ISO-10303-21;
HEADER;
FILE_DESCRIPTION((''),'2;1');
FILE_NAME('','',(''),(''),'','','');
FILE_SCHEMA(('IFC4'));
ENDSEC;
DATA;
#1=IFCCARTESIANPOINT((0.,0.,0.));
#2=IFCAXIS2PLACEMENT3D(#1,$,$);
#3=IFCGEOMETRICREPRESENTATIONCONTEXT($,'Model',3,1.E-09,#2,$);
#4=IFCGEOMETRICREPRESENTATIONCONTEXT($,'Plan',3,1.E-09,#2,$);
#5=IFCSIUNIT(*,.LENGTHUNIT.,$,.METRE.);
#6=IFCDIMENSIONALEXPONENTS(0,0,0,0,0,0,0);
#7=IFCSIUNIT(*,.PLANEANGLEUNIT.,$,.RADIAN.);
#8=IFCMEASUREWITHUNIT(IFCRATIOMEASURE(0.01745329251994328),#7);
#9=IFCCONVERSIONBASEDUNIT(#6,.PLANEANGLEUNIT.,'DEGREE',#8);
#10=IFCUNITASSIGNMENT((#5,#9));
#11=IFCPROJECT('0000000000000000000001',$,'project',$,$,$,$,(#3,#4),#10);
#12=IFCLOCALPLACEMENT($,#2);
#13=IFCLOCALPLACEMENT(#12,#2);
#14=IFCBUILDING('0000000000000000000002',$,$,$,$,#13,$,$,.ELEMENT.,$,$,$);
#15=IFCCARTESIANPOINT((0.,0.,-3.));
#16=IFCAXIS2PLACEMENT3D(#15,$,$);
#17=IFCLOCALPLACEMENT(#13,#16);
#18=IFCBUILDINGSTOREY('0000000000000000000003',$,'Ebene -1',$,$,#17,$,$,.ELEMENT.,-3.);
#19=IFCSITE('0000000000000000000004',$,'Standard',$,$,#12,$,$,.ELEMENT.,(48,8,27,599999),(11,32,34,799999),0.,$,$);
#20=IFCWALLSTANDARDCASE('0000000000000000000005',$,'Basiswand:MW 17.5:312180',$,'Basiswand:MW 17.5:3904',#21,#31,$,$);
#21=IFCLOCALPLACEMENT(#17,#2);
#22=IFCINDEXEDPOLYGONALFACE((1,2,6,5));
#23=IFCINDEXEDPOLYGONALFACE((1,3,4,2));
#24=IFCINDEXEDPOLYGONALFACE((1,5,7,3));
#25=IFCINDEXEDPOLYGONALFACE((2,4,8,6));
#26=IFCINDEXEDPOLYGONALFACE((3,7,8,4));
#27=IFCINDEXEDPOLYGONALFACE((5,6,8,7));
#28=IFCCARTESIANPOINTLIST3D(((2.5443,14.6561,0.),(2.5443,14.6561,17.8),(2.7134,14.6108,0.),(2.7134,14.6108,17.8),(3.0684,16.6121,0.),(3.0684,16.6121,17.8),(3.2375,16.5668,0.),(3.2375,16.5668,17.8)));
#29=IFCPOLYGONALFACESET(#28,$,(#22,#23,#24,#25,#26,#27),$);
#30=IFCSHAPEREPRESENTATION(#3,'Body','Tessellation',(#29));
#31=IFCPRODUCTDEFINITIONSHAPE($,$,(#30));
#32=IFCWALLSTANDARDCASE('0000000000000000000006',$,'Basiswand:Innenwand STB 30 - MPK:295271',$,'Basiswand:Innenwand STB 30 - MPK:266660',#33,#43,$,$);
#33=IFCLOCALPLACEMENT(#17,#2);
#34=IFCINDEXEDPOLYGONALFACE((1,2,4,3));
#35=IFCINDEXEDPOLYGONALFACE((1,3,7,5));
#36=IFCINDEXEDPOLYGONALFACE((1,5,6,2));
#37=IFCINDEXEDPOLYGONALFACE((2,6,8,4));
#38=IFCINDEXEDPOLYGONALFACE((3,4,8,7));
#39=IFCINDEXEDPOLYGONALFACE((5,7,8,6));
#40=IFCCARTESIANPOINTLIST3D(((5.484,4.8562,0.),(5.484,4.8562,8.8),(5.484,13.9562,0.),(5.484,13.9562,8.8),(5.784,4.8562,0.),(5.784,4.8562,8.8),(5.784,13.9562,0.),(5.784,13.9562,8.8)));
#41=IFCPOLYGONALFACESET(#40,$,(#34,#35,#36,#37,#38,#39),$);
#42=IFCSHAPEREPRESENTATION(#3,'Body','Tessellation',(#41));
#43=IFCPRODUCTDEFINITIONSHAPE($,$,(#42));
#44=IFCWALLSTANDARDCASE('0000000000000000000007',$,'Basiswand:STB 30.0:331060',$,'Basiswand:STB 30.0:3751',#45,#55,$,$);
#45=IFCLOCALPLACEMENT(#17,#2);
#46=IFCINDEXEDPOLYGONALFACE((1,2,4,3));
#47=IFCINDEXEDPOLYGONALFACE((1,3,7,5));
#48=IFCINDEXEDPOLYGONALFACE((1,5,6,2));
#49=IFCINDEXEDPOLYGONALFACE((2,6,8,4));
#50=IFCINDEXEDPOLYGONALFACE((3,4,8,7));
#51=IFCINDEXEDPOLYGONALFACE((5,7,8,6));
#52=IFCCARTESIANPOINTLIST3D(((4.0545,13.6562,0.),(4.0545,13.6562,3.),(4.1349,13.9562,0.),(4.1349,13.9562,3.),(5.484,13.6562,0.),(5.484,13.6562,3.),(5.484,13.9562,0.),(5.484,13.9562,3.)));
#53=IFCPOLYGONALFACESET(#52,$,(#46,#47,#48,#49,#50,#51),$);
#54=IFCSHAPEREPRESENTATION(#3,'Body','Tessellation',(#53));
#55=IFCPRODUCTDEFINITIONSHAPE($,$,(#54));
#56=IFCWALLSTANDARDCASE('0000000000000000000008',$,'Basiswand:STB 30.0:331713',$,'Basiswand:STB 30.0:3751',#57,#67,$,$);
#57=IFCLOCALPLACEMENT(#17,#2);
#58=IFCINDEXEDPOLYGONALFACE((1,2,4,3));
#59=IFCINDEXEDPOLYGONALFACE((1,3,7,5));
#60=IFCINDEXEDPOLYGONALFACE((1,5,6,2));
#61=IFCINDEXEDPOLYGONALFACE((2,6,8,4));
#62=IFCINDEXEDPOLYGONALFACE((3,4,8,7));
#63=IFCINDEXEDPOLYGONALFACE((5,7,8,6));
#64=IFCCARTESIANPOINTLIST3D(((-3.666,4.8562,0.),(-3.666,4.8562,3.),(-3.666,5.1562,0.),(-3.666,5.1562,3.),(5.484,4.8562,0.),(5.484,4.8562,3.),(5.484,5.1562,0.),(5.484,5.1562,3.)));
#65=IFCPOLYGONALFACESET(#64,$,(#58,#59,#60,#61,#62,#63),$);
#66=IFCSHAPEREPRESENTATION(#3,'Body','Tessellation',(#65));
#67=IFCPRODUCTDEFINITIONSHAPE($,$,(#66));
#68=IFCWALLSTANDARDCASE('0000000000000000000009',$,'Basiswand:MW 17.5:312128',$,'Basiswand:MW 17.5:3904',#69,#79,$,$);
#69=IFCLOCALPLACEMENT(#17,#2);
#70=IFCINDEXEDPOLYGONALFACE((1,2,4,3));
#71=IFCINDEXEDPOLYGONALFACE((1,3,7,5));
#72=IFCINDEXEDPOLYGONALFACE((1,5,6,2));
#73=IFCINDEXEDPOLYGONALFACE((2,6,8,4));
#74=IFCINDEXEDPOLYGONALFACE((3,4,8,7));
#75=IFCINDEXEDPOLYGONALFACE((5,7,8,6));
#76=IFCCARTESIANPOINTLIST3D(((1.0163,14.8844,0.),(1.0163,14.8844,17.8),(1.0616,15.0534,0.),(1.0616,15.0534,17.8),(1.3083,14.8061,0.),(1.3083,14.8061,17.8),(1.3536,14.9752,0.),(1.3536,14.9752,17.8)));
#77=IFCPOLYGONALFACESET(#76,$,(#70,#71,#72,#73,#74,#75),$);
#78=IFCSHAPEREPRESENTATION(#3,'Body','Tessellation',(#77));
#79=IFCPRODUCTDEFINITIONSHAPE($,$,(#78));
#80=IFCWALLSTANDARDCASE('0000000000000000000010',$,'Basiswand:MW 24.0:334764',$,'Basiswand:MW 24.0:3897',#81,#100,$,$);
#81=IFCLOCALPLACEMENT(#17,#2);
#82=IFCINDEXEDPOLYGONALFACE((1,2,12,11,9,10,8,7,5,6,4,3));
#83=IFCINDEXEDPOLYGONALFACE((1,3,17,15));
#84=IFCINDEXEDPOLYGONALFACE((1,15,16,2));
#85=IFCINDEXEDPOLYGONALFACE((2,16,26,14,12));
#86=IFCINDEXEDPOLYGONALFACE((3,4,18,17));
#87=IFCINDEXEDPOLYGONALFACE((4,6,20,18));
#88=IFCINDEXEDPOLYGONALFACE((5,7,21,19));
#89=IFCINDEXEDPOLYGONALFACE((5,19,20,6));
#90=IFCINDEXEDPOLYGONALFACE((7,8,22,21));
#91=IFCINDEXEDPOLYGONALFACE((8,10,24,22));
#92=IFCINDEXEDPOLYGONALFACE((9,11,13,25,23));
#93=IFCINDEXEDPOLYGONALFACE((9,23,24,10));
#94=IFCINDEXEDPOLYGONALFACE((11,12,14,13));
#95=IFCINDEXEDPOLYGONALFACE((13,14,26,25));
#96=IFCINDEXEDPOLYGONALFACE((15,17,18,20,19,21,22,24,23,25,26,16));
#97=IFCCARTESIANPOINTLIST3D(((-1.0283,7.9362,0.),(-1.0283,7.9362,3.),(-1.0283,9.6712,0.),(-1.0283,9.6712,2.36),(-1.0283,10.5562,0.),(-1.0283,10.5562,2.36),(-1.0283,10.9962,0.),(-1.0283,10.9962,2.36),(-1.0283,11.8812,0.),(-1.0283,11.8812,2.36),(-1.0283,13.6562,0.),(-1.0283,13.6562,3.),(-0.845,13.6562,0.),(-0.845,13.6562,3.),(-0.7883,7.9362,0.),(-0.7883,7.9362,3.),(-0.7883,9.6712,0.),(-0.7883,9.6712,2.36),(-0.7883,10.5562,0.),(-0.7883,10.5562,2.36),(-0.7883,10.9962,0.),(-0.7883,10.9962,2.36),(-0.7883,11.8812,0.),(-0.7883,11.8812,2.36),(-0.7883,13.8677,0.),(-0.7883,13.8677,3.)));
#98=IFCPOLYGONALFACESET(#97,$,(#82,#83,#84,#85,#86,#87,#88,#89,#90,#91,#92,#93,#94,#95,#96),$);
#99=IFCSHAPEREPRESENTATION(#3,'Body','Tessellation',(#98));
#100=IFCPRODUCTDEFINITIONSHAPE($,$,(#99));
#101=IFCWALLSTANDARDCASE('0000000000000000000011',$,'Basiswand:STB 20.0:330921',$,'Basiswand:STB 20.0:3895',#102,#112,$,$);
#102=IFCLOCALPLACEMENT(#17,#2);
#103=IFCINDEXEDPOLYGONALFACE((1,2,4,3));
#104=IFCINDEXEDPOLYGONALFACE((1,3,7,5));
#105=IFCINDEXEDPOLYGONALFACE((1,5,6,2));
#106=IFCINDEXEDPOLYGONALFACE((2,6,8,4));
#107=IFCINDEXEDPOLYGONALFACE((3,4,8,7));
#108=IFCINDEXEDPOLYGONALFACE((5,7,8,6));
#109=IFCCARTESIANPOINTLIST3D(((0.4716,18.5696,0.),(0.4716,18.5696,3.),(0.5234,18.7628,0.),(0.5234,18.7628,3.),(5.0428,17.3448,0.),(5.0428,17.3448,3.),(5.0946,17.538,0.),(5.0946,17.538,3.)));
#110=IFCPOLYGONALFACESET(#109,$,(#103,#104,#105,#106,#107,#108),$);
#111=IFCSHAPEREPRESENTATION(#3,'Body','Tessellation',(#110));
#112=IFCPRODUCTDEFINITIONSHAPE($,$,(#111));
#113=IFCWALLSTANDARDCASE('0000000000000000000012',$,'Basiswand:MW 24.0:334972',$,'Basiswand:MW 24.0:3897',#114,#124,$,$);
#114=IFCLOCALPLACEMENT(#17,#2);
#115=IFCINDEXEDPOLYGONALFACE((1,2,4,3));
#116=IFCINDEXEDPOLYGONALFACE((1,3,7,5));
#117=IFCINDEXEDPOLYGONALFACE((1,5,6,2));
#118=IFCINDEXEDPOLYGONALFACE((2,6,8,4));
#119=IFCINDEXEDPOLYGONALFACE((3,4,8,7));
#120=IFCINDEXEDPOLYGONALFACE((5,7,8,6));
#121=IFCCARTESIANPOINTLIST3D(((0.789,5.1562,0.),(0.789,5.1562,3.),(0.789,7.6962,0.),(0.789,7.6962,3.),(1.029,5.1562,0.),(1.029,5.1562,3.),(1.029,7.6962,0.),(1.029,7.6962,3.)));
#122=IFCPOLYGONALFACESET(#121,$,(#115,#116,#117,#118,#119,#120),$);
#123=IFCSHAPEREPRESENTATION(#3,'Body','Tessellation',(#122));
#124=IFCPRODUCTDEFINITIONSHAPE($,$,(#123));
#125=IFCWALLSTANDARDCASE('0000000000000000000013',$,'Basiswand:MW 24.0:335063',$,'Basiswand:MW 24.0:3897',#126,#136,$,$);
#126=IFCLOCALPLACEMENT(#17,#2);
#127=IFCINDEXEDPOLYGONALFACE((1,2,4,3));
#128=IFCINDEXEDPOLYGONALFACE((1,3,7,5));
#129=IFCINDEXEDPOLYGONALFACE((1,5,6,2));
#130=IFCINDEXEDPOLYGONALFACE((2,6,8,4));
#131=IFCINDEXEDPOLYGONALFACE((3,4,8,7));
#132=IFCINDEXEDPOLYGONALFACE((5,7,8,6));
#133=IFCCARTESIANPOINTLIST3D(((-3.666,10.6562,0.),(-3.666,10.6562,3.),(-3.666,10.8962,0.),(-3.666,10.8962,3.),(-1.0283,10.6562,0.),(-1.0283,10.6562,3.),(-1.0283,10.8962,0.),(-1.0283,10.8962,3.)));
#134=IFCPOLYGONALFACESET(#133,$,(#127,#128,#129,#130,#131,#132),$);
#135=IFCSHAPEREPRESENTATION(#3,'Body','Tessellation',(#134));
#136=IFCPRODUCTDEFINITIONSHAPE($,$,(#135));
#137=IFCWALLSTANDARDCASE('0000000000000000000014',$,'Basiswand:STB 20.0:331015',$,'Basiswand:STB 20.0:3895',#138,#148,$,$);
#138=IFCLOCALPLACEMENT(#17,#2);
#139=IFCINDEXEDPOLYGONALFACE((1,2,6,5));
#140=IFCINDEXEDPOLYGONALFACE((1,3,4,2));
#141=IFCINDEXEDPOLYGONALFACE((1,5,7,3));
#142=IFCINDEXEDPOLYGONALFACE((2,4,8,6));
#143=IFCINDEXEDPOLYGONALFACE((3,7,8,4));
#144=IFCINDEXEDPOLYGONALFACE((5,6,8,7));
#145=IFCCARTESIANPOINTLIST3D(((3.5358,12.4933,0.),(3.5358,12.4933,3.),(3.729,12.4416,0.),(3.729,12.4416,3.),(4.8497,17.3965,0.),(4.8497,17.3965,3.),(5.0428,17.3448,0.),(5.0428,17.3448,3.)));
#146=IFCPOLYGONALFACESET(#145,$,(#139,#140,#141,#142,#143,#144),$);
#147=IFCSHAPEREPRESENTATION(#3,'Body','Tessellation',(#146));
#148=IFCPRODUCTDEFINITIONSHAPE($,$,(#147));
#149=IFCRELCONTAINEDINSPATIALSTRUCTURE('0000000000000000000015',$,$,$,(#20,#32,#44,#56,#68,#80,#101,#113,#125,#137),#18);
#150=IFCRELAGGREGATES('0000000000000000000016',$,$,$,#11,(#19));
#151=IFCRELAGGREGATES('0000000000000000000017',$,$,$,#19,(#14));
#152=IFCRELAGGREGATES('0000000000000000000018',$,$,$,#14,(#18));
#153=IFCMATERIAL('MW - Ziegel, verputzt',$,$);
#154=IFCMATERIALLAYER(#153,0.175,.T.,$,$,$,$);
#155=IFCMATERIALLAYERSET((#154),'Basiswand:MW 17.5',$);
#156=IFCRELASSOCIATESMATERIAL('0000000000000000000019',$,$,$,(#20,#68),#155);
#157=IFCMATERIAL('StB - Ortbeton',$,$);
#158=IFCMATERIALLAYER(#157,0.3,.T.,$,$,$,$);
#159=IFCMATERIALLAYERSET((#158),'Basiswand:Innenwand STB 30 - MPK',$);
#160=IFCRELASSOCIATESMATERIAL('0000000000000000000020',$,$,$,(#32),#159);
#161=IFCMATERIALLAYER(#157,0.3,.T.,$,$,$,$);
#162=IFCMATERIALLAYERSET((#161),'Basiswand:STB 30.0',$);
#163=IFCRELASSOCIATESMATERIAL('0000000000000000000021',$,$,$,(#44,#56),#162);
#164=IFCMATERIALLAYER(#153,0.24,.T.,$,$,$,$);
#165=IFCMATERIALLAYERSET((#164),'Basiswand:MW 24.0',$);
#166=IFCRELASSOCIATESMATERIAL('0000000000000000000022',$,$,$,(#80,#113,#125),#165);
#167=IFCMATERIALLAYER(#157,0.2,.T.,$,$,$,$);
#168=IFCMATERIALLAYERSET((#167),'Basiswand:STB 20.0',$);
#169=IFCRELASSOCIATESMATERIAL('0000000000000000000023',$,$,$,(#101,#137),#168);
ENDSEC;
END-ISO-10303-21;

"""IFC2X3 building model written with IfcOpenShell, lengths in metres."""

from ifc_helpers import new_model, entity, si_unit, converted_unit, frame, frame_2d, origin, place, context, project, spatial, polyline, rectangle, outline, extrude, clip, bounded_halfspace, material, layer, layer_set, layer_usage, element, save


model = new_model("IFC2X3")

# Units and contexts
model_context = context("Model", 3, precision=1e-09, world=origin())
plan_context = context("Plan", 3, precision=1e-09, world=origin())
ifc_project = project(units=[si_unit("LENGTHUNIT", "METRE"), converted_unit("PLANEANGLEUNIT", "DEGREE", entity("IfcRatioMeasure", 0.01745329251994328), si_unit("PLANEANGLEUNIT", "RADIAN"), dimensions=[0, 0, 0, 0, 0, 0, 0])], contexts=[model_context, plan_context])

# Site, building, storey
site_placement = place(None, origin())
site = spatial("IfcSite", under=ifc_project, at=site_placement, Name="Standard", CompositionType="ELEMENT", RefLatitude=(48, 8, 27, 599999), RefLongitude=(11, 32, 34, 799999), RefElevation=0.0)
building_placement = place(site_placement, origin())
building = spatial("IfcBuilding", under=site, at=building_placement, CompositionType="ELEMENT")
storey_placement = place(building_placement, frame((0.0, 0.0, -3.0)))
storey = spatial("IfcBuildingStorey", under=building, at=storey_placement, Name="Ebene -1", CompositionType="ELEMENT", Elevation=-3.0)

# Shared definitions
ifc_material_1 = material(Name="StB - Ortbeton")

# Shared definitions
ifc_layer_1 = layer(ifc_material_1, 0.3, ventilated=True)
ifc_layer_set_1 = layer_set([ifc_layer_1], Name="Basiswand:STB 30.0")
ifc_material_2 = material(Name="MW - Ziegel, verputzt")
ifc_layer_2 = layer(ifc_material_2, 0.24, ventilated=True)
ifc_layer_set_2 = layer_set([ifc_layer_2], Name="Basiswand:MW 24.0")

# Walls
ifc_layer_3 = layer(ifc_material_1, 0.3, ventilated=True)
ifc_layer_set_3 = layer_set([ifc_layer_3], Name="Basiswand:Innenwand STB 30 - MPK")
ifc_layer_4 = layer(ifc_material_2, 0.175, ventilated=True)
ifc_layer_set_4 = layer_set([ifc_layer_4], Name="Basiswand:MW 17.5")
ifc_layer_5 = layer(ifc_material_1, 0.2, ventilated=True)
ifc_layer_set_5 = layer_set([ifc_layer_5], Name="Basiswand:STB 20.0")
ifc_layer_usage_1 = layer_usage(ifc_layer_set_4, "AXIS2", "NEGATIVE", 0.0875)
wall_1_placement = place(storey_placement, frame((2.6288, 14.6335, 0.0), z_axis=(0.0, 0.0, 1.0), x_axis=(0.258819, 0.965926, 0.0)))
element("IfcWallStandardCase", 1, at=wall_1_placement, inside=storey, material=ifc_layer_usage_1, Name="Basiswand:MW 17.5:312180", ObjectType="Basiswand:MW 17.5:3904", context=model_context, shape_type="Clipping", body=[
    clip(extrude(rectangle(XDim=2.025, YDim=0.175, at=frame_2d((1.0125, 0.0), x_axis=(-1.0, 0.0))), origin(), (0.0, 0.0, 1.0), 17.8), bounded_halfspace(frame((0.0, -0.0875, 17.8), z_axis=(0.0, 0.0, -1.0), x_axis=(0.0, -1.0, 0.0)), True, frame((0.0, -0.0875, 17.8)), polyline([(0.0, 0.0), (2.025, 0.0), (2.025, 0.175), (1.85, 0.175), (0.0, 0.175), (0.0, 0.0)]))),
])
ifc_layer_usage_2 = layer_usage(ifc_layer_set_3, "AXIS2", "NEGATIVE", 0.15)
wall_2_placement = place(storey_placement, frame((5.634, 4.8562, 0.0), z_axis=(0.0, 0.0, 1.0), x_axis=(0.0, 1.0, 0.0)))
element("IfcWallStandardCase", 2, at=wall_2_placement, inside=storey, material=ifc_layer_usage_2, Name="Basiswand:Innenwand STB 30 - MPK:295271", ObjectType="Basiswand:Innenwand STB 30 - MPK:266660", context=model_context, shape_type="Clipping", body=[
    clip(extrude(rectangle(XDim=9.1, YDim=0.3, at=frame_2d((4.55, 0.0), x_axis=(-1.0, 0.0))), origin(), (0.0, 0.0, 1.0), 8.8), bounded_halfspace(frame((0.0, -0.15, 8.8), z_axis=(0.0, 0.0, -1.0), x_axis=(-1.0, 0.0, 0.0)), True, frame((0.0, -0.15, 8.8)), polyline([(0.0, 0.0), (9.1, 0.0), (9.1, 0.3), (0.0, 0.3), (0.0, 0.0)]))),
])
ifc_layer_usage_3 = layer_usage(ifc_layer_set_1, "AXIS2", "NEGATIVE", 0.15)
wall_3_placement = place(storey_placement, frame((4.0545, 13.8062, 0.0)))
element("IfcWallStandardCase", 3, at=wall_3_placement, inside=storey, material=ifc_layer_usage_3, Name="Basiswand:STB 30.0:331060", ObjectType="Basiswand:STB 30.0:3751", context=model_context, shape_type="SweptSolid", body=[
    extrude(outline(polyline([(1.4295, -0.15), (1.4295, 0.15), (0.0804, 0.15), (0.0, -0.15), (1.4295, -0.15)])), origin(), (0.0, 0.0, 1.0), 3.0),
])
ifc_layer_usage_4 = layer_usage(ifc_layer_set_1, "AXIS2", "NEGATIVE", 0.15)
wall_4_placement = place(storey_placement, frame((5.484, 5.0062, 0.0), z_axis=(0.0, 0.0, 1.0), x_axis=(-1.0, 0.0, 0.0)))
element("IfcWallStandardCase", 4, at=wall_4_placement, inside=storey, material=ifc_layer_usage_4, Name="Basiswand:STB 30.0:331713", ObjectType="Basiswand:STB 30.0:3751", context=model_context, shape_type="SweptSolid", body=[
    extrude(rectangle(XDim=9.15, YDim=0.3, at=frame_2d((4.575, 0.0), x_axis=(-1.0, 0.0))), origin(), (0.0, 0.0, 1.0), 3.0),
])
ifc_layer_usage_5 = layer_usage(ifc_layer_set_4, "AXIS2", "NEGATIVE", 0.0875)
wall_5_placement = place(storey_placement, frame((1.039, 14.9689, 0.0), z_axis=(0.0, 0.0, 1.0), x_axis=(0.965926, -0.258819, 0.0)))
element("IfcWallStandardCase", 5, at=wall_5_placement, inside=storey, material=ifc_layer_usage_5, Name="Basiswand:MW 17.5:312128", ObjectType="Basiswand:MW 17.5:3904", context=model_context, shape_type="Clipping", body=[
    clip(extrude(rectangle(XDim=0.3023, YDim=0.175, at=frame_2d((0.1511, 0.0), x_axis=(-1.0, 0.0))), origin(), (0.0, 0.0, 1.0), 17.8), bounded_halfspace(frame((0.0, -0.0875, 17.8), z_axis=(0.0, 0.0, -1.0), x_axis=(1.0, 0.0, 0.0)), True, frame((0.0, -0.0875, 17.8)), polyline([(0.0, 0.0), (0.3023, 0.0), (0.3023, 0.175), (0.0, 0.175), (0.0, 0.0)]))),
])

# Wall, openings
ifc_layer_usage_6 = layer_usage(ifc_layer_set_2, "AXIS2", "NEGATIVE", 0.12)
wall_6_placement = place(storey_placement, frame((-0.9083, 13.8677, 0.0), z_axis=(0.0, 0.0, 1.0), x_axis=(0.0, -1.0, 0.0)))
wall_6 = element("IfcWallStandardCase", 6, at=wall_6_placement, inside=storey, material=ifc_layer_usage_6, Name="Basiswand:MW 24.0:334764", ObjectType="Basiswand:MW 24.0:3897", context=model_context, shape_type="SweptSolid", body=[
    extrude(outline(polyline([(0.2115, -0.12), (2.9715, -0.12), (3.2115, -0.12), (5.9315, -0.12), (5.9315, 0.12), (0.2157, 0.12), (0.0, 0.12), (0.2115, 0.0633), (0.2115, -0.12)])), origin(), (0.0, 0.0, 1.0), 3.0),
])
opening_1_placement = place(wall_6_placement, frame((3.3115, -0.12, 0.0)))
element("IfcOpeningElement", 7, at=opening_1_placement, cuts=wall_6, ObjectType="Opening", context=model_context, shape_type="SweptSolid", body=[
    extrude(rectangle(XDim=2.36, YDim=0.885, at=frame_2d((1.18, 0.4425), x_axis=(1.0, 0.0))), frame((0.0, 0.0, 0.0), z_axis=(0.0, 1.0, 0.0), x_axis=(0.0, 0.0, 1.0)), (0.0, 0.0, 1.0), 0.24),
])
opening_2_placement = place(wall_6_placement, frame((1.9865, -0.12, 0.0)))
element("IfcOpeningElement", 8, at=opening_2_placement, cuts=wall_6, ObjectType="Opening", context=model_context, shape_type="SweptSolid", body=[
    extrude(rectangle(XDim=2.36, YDim=0.885, at=frame_2d((1.18, 0.4425), x_axis=(1.0, 0.0))), frame((0.0, 0.0, 0.0), z_axis=(0.0, 1.0, 0.0), x_axis=(0.0, 0.0, 1.0)), (0.0, 0.0, 1.0), 0.24),
])

# Walls
ifc_layer_usage_7 = layer_usage(ifc_layer_set_5, "AXIS2", "NEGATIVE", 0.1)
wall_7_placement = place(storey_placement, frame((0.4975, 18.6662, 0.0), z_axis=(0.0, 0.0, 1.0), x_axis=(0.965926, -0.258819, 0.0)))
element("IfcWallStandardCase", 9, at=wall_7_placement, inside=storey, material=ifc_layer_usage_7, Name="Basiswand:STB 20.0:330921", ObjectType="Basiswand:STB 20.0:3895", context=model_context, shape_type="SweptSolid", body=[
    extrude(rectangle(XDim=4.7325, YDim=0.2, at=frame_2d((2.3662, 0.0), x_axis=(-1.0, 0.0))), origin(), (0.0, 0.0, 1.0), 3.0),
])
ifc_layer_usage_8 = layer_usage(ifc_layer_set_2, "AXIS2", "NEGATIVE", 0.12)
wall_8_placement = place(storey_placement, frame((0.909, 7.6962, 0.0), z_axis=(0.0, 0.0, 1.0), x_axis=(0.0, -1.0, 0.0)))
element("IfcWallStandardCase", 10, at=wall_8_placement, inside=storey, material=ifc_layer_usage_8, Name="Basiswand:MW 24.0:334972", ObjectType="Basiswand:MW 24.0:3897", context=model_context, shape_type="SweptSolid", body=[
    extrude(rectangle(XDim=2.54, YDim=0.24, at=frame_2d((1.27, 0.0), x_axis=(-1.0, 0.0))), origin(), (0.0, 0.0, 1.0), 3.0),
])
ifc_layer_usage_9 = layer_usage(ifc_layer_set_2, "AXIS2", "NEGATIVE", 0.12)
wall_9_placement = place(storey_placement, frame((-1.0283, 10.7762, 0.0), z_axis=(0.0, 0.0, 1.0), x_axis=(-1.0, 0.0, 0.0)))
element("IfcWallStandardCase", 11, at=wall_9_placement, inside=storey, material=ifc_layer_usage_9, Name="Basiswand:MW 24.0:335063", ObjectType="Basiswand:MW 24.0:3897", context=model_context, shape_type="SweptSolid", body=[
    extrude(rectangle(XDim=2.6377, YDim=0.24, at=frame_2d((1.3189, 0.0), x_axis=(-1.0, 0.0))), origin(), (0.0, 0.0, 1.0), 3.0),
])
ifc_layer_usage_10 = layer_usage(ifc_layer_set_5, "AXIS2", "NEGATIVE", 0.1)
wall_10_placement = place(storey_placement, frame((4.9462, 17.3707, 0.0), z_axis=(0.0, 0.0, 1.0), x_axis=(-0.258819, -0.965926, 0.0)))
element("IfcWallStandardCase", 12, at=wall_10_placement, inside=storey, material=ifc_layer_usage_10, Name="Basiswand:STB 20.0:331015", ObjectType="Basiswand:STB 20.0:3895", context=model_context, shape_type="SweptSolid", body=[
    extrude(rectangle(XDim=5.0762, YDim=0.2, at=frame_2d((2.5381, 0.0), x_axis=(-1.0, 0.0))), origin(), (0.0, 0.0, 1.0), 3.0),
])

save(model, "model.ifc")
